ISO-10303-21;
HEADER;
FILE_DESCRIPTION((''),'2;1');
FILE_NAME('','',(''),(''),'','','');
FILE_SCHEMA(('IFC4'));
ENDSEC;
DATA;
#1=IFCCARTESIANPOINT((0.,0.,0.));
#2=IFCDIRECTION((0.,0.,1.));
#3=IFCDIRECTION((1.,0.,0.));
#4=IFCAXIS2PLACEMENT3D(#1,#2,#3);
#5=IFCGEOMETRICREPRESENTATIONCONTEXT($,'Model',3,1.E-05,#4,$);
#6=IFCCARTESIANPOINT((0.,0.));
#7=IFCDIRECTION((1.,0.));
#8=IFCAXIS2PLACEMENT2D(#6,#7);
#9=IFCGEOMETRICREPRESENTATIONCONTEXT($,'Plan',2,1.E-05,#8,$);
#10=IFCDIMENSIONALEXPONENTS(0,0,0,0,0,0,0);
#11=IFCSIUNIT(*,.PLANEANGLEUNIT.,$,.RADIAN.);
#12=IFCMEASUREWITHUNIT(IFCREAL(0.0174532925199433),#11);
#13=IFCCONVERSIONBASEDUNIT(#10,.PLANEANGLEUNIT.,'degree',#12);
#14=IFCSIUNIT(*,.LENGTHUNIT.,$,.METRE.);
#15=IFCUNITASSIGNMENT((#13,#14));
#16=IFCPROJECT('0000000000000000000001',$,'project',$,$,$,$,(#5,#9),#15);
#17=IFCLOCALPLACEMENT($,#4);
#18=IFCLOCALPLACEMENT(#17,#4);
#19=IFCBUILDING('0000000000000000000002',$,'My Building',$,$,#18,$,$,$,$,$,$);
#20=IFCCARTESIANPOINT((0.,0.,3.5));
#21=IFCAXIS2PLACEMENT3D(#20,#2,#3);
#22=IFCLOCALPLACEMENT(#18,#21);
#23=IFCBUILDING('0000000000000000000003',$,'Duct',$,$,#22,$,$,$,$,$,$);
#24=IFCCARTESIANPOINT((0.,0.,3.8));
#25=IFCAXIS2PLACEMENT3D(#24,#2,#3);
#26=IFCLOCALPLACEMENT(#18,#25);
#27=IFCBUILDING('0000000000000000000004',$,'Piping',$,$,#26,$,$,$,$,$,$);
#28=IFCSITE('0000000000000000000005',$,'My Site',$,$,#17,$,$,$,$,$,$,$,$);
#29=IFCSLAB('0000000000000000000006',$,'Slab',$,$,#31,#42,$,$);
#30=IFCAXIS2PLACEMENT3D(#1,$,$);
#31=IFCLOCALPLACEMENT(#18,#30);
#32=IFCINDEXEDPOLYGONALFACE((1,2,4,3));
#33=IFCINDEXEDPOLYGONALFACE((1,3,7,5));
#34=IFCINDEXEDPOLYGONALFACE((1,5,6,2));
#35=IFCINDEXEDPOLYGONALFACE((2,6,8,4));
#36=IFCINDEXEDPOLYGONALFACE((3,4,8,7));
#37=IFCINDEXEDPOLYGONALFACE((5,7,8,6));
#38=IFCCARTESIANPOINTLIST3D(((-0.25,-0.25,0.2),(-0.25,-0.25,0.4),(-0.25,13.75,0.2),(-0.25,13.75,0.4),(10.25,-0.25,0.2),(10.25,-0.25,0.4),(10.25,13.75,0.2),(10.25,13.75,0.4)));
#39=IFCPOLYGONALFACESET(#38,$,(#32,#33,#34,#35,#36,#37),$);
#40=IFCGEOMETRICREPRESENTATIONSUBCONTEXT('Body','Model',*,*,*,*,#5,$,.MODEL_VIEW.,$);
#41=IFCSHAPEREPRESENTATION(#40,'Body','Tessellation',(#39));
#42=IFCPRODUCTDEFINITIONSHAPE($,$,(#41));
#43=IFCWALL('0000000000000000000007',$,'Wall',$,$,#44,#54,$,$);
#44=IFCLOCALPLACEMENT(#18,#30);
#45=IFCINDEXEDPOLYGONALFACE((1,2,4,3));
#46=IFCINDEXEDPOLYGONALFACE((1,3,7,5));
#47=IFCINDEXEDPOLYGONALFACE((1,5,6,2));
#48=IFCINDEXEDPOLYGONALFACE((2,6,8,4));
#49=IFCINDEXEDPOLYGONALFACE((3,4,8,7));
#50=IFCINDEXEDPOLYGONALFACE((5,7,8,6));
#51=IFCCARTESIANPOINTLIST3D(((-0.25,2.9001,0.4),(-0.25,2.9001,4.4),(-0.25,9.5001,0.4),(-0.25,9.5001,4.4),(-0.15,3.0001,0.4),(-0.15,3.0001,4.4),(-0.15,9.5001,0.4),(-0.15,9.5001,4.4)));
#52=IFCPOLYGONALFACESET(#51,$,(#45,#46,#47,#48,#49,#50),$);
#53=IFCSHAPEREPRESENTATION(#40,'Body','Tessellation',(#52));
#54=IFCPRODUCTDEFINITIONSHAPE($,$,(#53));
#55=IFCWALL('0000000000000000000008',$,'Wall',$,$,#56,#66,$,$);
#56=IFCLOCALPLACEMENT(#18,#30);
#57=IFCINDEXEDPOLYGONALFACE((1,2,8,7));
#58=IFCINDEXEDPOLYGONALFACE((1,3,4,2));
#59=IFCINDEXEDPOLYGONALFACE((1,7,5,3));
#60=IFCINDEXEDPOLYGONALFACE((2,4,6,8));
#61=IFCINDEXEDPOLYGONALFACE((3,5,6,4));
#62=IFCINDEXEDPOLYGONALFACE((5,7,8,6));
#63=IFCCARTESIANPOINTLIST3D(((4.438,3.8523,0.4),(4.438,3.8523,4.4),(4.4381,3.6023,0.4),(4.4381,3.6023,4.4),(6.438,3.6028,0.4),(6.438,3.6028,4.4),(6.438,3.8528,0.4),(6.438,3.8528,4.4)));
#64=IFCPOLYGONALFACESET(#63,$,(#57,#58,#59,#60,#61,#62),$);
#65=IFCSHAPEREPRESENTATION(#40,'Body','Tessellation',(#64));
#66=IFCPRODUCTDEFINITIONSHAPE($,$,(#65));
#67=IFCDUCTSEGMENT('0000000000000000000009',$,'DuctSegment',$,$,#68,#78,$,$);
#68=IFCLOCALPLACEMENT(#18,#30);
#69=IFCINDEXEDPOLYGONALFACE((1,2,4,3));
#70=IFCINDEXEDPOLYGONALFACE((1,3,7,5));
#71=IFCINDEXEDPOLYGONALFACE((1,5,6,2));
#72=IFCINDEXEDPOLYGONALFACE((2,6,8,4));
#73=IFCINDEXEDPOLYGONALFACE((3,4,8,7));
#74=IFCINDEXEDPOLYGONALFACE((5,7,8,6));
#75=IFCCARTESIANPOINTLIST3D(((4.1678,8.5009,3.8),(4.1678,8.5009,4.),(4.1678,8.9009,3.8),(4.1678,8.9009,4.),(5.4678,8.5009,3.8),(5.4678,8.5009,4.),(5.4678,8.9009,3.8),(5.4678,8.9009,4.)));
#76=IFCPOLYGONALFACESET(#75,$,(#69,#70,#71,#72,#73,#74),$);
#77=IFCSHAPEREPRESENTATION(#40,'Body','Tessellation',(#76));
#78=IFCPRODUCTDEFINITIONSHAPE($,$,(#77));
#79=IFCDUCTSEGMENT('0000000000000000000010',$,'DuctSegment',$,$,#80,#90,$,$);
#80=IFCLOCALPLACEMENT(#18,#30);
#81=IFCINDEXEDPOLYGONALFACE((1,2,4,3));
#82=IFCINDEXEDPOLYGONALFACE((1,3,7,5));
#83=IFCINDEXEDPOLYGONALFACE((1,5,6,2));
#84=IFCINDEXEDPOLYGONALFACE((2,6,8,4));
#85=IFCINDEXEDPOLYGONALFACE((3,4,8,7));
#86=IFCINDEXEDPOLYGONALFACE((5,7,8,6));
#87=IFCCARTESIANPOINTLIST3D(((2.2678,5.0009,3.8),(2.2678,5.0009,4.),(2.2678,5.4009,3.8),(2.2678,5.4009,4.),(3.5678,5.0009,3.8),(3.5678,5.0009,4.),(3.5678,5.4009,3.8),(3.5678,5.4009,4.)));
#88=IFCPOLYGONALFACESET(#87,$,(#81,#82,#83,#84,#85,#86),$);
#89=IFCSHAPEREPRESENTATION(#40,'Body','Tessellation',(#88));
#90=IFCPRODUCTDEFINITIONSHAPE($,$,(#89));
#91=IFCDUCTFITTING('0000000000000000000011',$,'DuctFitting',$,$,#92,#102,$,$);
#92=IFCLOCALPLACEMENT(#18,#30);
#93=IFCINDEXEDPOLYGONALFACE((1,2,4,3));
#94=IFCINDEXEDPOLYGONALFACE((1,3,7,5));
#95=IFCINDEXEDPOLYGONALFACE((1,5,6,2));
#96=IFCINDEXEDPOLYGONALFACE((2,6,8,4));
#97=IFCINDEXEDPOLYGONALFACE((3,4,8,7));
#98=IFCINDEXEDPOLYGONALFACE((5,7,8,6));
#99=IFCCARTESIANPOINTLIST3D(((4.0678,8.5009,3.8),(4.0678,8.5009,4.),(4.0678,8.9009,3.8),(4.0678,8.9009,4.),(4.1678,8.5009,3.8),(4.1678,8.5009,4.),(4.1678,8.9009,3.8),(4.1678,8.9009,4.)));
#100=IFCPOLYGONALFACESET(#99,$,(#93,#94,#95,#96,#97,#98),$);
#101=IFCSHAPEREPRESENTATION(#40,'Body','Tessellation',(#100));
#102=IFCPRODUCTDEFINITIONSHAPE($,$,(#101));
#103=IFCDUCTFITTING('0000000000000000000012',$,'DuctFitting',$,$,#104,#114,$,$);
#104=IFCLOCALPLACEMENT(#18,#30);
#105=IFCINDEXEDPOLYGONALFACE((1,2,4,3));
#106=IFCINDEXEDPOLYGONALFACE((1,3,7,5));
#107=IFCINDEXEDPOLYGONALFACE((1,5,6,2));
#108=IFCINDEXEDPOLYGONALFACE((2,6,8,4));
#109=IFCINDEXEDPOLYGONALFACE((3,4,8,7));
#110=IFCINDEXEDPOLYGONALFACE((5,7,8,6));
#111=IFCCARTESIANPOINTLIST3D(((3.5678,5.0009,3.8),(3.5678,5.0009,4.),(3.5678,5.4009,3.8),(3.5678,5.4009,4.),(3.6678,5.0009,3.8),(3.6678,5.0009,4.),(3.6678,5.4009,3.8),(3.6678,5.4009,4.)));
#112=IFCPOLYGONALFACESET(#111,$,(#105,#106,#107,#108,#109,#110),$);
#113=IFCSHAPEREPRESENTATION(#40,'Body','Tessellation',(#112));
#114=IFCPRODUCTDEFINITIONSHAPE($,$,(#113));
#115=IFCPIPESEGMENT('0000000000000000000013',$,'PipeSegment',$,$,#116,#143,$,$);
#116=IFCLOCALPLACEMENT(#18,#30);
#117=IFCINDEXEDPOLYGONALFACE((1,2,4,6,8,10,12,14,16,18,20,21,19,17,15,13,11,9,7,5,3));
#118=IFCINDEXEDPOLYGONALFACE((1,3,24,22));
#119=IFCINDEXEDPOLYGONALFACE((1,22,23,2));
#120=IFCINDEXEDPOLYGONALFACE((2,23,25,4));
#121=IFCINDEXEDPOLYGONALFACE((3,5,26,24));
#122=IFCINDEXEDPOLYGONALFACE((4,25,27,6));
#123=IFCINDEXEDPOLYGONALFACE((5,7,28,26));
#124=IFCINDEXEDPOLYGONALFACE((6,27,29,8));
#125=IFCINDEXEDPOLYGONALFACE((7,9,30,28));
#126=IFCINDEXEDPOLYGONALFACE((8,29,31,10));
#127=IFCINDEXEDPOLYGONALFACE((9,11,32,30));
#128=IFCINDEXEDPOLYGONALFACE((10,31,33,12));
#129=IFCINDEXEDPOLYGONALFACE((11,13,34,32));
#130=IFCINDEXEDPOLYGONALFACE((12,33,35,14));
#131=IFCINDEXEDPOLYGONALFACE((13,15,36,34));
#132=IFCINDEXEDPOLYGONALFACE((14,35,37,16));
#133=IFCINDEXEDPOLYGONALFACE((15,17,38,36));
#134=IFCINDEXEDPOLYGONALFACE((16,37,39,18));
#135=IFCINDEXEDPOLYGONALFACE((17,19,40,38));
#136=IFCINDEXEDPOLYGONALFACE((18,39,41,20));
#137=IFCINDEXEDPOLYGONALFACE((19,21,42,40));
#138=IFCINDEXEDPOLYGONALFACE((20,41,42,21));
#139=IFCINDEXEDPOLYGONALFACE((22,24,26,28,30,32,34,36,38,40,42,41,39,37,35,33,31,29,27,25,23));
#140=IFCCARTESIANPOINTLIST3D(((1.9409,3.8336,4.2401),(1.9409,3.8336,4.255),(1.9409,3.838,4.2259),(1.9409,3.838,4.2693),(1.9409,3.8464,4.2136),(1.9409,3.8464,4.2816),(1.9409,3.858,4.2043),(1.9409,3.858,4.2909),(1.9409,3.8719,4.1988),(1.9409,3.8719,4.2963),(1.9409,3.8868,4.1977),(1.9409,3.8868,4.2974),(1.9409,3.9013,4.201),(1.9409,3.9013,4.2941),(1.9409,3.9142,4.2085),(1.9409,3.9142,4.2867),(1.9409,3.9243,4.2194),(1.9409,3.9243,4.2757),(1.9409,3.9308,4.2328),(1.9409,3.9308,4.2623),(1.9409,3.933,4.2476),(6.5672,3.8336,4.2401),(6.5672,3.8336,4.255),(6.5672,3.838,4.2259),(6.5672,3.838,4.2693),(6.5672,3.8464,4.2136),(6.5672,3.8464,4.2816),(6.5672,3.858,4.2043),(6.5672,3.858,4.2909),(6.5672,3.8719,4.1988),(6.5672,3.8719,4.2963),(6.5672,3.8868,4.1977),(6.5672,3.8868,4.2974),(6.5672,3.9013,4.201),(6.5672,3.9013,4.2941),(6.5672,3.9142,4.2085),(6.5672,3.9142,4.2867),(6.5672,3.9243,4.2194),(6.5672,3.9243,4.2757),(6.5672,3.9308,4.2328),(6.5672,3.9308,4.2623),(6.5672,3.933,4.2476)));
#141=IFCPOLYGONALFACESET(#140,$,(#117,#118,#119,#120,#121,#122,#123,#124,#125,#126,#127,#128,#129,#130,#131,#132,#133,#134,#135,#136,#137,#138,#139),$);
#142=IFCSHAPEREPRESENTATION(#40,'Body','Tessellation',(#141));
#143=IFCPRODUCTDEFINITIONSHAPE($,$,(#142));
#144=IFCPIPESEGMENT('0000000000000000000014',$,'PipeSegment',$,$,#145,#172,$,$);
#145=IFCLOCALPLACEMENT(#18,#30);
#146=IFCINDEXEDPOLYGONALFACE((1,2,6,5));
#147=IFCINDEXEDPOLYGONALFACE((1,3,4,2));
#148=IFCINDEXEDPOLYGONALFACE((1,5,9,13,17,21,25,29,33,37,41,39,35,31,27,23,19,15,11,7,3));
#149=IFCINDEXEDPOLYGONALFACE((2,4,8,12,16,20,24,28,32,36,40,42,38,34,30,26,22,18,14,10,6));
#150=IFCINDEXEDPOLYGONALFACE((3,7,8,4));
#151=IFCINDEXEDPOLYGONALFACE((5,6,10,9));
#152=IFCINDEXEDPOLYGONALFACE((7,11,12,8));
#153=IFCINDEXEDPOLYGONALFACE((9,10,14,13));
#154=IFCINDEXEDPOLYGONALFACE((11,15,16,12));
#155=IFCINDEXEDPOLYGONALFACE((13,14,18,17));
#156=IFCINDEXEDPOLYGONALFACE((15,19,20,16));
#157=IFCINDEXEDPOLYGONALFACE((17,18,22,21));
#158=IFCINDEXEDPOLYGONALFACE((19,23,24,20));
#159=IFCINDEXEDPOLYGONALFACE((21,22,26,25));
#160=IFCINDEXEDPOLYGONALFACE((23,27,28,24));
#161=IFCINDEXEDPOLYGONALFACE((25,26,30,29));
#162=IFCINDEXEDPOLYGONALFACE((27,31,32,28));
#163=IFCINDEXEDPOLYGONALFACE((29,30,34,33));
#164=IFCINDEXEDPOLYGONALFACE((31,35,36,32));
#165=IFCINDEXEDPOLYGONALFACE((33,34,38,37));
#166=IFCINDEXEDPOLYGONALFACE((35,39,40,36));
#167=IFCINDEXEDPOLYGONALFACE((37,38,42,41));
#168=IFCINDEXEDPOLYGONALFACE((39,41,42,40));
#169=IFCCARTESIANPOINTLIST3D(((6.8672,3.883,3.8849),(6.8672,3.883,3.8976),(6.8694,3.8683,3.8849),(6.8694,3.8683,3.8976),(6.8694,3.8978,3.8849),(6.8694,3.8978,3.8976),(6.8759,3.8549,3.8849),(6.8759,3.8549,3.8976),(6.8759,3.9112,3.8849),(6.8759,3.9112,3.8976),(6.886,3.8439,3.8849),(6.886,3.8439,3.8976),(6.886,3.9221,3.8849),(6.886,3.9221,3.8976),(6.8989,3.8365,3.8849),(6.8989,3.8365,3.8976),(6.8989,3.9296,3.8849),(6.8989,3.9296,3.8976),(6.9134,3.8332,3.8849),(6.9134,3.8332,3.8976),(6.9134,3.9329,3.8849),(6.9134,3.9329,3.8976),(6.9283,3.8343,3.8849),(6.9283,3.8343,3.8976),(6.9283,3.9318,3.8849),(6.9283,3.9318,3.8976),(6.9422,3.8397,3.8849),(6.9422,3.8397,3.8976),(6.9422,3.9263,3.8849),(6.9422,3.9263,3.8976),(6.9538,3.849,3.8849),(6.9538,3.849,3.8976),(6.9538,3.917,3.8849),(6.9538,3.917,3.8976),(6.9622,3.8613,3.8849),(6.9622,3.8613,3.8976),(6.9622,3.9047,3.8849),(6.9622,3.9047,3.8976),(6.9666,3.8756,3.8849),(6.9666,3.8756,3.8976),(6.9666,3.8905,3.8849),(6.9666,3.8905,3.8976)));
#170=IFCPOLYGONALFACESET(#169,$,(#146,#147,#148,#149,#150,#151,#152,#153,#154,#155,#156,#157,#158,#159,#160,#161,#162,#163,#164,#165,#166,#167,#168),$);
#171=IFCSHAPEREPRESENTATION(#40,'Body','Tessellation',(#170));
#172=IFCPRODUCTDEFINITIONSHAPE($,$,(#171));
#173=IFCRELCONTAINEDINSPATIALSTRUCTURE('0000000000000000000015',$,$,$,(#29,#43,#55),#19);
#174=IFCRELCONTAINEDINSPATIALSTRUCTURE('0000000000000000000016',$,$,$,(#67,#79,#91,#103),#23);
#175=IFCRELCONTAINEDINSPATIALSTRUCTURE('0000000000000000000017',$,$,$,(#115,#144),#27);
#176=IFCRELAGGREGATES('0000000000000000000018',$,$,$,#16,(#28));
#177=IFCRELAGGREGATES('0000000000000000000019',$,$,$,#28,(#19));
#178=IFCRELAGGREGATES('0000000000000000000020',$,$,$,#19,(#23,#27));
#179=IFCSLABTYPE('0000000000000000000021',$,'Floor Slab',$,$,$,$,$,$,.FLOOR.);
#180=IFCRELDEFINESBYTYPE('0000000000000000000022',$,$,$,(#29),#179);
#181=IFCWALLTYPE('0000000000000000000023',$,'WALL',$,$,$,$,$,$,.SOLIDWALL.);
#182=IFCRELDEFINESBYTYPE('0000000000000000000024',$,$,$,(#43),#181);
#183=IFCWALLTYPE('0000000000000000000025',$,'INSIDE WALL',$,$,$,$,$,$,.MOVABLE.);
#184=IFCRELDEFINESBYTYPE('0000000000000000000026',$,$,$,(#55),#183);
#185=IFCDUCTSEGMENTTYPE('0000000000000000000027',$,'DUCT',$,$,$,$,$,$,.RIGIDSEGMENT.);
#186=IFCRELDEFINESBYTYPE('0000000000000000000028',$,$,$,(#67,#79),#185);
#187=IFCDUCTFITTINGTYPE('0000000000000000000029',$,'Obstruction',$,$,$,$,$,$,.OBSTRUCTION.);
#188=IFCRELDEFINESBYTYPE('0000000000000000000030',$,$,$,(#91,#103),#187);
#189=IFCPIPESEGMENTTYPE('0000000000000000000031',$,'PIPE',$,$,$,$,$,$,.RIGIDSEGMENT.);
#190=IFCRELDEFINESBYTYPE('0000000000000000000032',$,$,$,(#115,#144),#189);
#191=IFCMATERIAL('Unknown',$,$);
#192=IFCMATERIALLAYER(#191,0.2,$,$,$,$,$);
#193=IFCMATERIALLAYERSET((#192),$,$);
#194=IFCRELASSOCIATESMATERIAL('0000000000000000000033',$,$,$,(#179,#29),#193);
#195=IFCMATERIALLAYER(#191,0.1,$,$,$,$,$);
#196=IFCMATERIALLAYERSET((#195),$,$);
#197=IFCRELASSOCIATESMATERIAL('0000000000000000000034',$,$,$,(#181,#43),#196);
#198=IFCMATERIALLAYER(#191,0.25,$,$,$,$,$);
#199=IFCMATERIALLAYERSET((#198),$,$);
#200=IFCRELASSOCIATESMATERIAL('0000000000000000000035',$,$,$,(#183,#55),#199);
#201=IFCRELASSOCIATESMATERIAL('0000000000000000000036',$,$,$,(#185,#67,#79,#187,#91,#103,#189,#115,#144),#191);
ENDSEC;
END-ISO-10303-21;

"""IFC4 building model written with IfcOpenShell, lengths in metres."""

from ifc_helpers import new_model, entity, si_unit, converted_unit, frame, origin_with_axes, origin_2d_with_axis, place, context, subcontext, project, spatial, line, indexed_curve, rectangle, circle, outline, extrude, material, layer, layer_set, layer_usage, material_profile, profile_set, profile_usage, type_object, element, save


model = new_model("IFC4")

# Units and contexts
model_context = context("Model", 3, precision=1e-05, world=origin_with_axes())
plan_context = context("Plan", 2, precision=1e-05, world=origin_2d_with_axis())
body_context = subcontext(model_context, "Body", "Model", "MODEL_VIEW")
ifc_project = project(units=[converted_unit("PLANEANGLEUNIT", "degree", entity("IfcReal", 0.0174532925199433), si_unit("PLANEANGLEUNIT", "RADIAN"), dimensions=[0, 0, 0, 0, 0, 0, 0]), si_unit("LENGTHUNIT", "METRE")], contexts=[model_context, plan_context])

# Site, building
site_placement = place(None, origin_with_axes())
site = spatial("IfcSite", under=ifc_project, at=site_placement, Name="My Site")
building_1_placement = place(site_placement, origin_with_axes())
building_1 = spatial("IfcBuilding", under=site, at=building_1_placement, Name="My Building")

# Slab
ifc_material = material(Name="Unknown")
ifc_layer_1 = layer(ifc_material, 0.2)
ifc_layer_set_1 = layer_set([ifc_layer_1])
ifc_layer_usage_1 = layer_usage(ifc_layer_set_1, "AXIS3", "POSITIVE", 0.0)
slab_type = type_object("IfcSlabType", Name="Floor Slab", PredefinedType="FLOOR", material=ifc_layer_set_1)
slab_placement = place(building_1_placement, frame((-0.25, -0.25, 0.2), z_axis=(0.0, 0.0, 1.0), x_axis=(1.0, 0.0, 0.0)))
element("IfcSlab", 1, at=slab_placement, inside=building_1, type_object=slab_type, material=ifc_layer_usage_1, Name="Slab", context=body_context, shape_type="SweptSolid", body=[
    extrude(outline(indexed_curve([(0.0, 0.0), (10.5, 0.0), (10.5, 14.0), (0.0, 14.0), (0.0, 0.0)])), None, (0.0, 0.0, 1.0), 0.2),
])

# Walls
ifc_layer_2 = layer(ifc_material, 0.1)
ifc_layer_set_2 = layer_set([ifc_layer_2])
ifc_layer_usage_2 = layer_usage(ifc_layer_set_2, "AXIS2", "POSITIVE", 0.0)
wall_type_1 = type_object("IfcWallType", Name="WALL", PredefinedType="SOLIDWALL", material=ifc_layer_set_2)
wall_1_placement = place(building_1_placement, frame((-0.15, 3.0001, 0.4), z_axis=(0.0, 0.0, 1.0), x_axis=(0.0, 1.0, 0.0)))
element("IfcWall", 2, at=wall_1_placement, inside=building_1, type_object=wall_type_1, material=ifc_layer_usage_2, Name="Wall", context=body_context, shape_type="SweptSolid", body=[
    extrude(outline(indexed_curve([(0.0, 0.0), (-0.1, 0.1), (6.5, 0.1), (6.5, 0.0)], segments=[line(1, 2, 3, 4, 1)])), origin_with_axes(), (0.0, 0.0, 1.0), 4.0),
])
ifc_layer_3 = layer(ifc_material, 0.25)
ifc_layer_set_3 = layer_set([ifc_layer_3])
ifc_layer_usage_3 = layer_usage(ifc_layer_set_3, "AXIS2", "POSITIVE", 0.0)
wall_type_2 = type_object("IfcWallType", Name="INSIDE WALL", PredefinedType="MOVABLE", material=ifc_layer_set_3)
wall_2_placement = place(building_1_placement, frame((6.438, 3.8528, 0.4), z_axis=(0.0, 0.0, 1.0), x_axis=(-1.0, -0.000252, 0.0)))
element("IfcWall", 3, at=wall_2_placement, inside=building_1, type_object=wall_type_2, material=ifc_layer_usage_3, Name="Wall", context=body_context, shape_type="SweptSolid", body=[
    extrude(outline(indexed_curve([(0.0, 0.0), (0.0, 0.25), (2.0, 0.25), (2.0, 0.0)], segments=[line(1, 2, 3, 4, 1)])), origin_with_axes(), (0.0, 0.0, 1.0), 4.0),
])

# Shared definitions
building_2_placement = place(building_1_placement, frame((0.0, 0.0, 3.5), z_axis=(0.0, 0.0, 1.0), x_axis=(1.0, 0.0, 0.0)))
building_2 = spatial("IfcBuilding", under=building_1, at=building_2_placement, Name="Duct")

# Duct segments
ifc_material_profile_1 = material_profile(ifc_material, rectangle(XDim=0.4, YDim=0.2))
ifc_profile_set_1 = profile_set([ifc_material_profile_1])
ifc_profile_usage_1 = profile_usage(ifc_profile_set_1, cardinal=5)
duct_segment_type = type_object("IfcDuctSegmentType", Name="DUCT", PredefinedType="RIGIDSEGMENT", material=ifc_profile_set_1)
duct_segment_1_placement = place(building_2_placement, frame((5.4678, 8.7009, 0.4), z_axis=(-1.0, 0.0, 0.0), x_axis=(0.0, 1.0, 0.0)))
element("IfcDuctSegment", 4, at=duct_segment_1_placement, inside=building_2, type_object=duct_segment_type, material=ifc_profile_usage_1, Name="DuctSegment", context=body_context, shape_type="SweptSolid", body=[
    extrude(rectangle(XDim=0.4, YDim=0.2), origin_with_axes(), (0.0, 0.0, 1.0), 1.3),
])
ifc_profile_usage_2 = profile_usage(ifc_profile_set_1, cardinal=5)
duct_segment_2_placement = place(building_2_placement, frame((3.5678, 5.2009, 0.4), z_axis=(-1.0, 0.0, 0.0), x_axis=(0.0, -1.0, 0.0)))
element("IfcDuctSegment", 5, at=duct_segment_2_placement, inside=building_2, type_object=duct_segment_type, material=ifc_profile_usage_2, Name="DuctSegment", context=body_context, shape_type="SweptSolid", body=[
    extrude(rectangle(XDim=0.4, YDim=0.2), origin_with_axes(), (0.0, 0.0, 1.0), 1.3),
])

# Duct fittings
ifc_material_profile_2 = material_profile(ifc_material, rectangle(XDim=0.4, YDim=0.2))
ifc_profile_set_2 = profile_set([ifc_material_profile_2])
ifc_profile_usage_3 = profile_usage(ifc_profile_set_2, cardinal=5)
duct_fitting_type = type_object("IfcDuctFittingType", Name="Obstruction", PredefinedType="OBSTRUCTION", material=ifc_profile_set_2)
duct_fitting_1_placement = place(building_2_placement, frame((4.1678, 8.7009, 0.4), z_axis=(-1.0, 0.0, 0.0), x_axis=(0.0, 1.0, 0.0)))
element("IfcDuctFitting", 6, at=duct_fitting_1_placement, inside=building_2, type_object=duct_fitting_type, material=ifc_profile_usage_3, Name="DuctFitting", context=body_context, shape_type="SweptSolid", body=[
    extrude(rectangle(XDim=0.4, YDim=0.2), origin_with_axes(), (0.0, 0.0, 1.0), 0.1),
])
ifc_profile_usage_4 = profile_usage(ifc_profile_set_2, cardinal=5)
duct_fitting_2_placement = place(building_2_placement, frame((3.6678, 5.2009, 0.4), z_axis=(-1.0, 0.0, 0.0), x_axis=(0.0, -1.0, 0.0)))
element("IfcDuctFitting", 7, at=duct_fitting_2_placement, inside=building_2, type_object=duct_fitting_type, material=ifc_profile_usage_4, Name="DuctFitting", context=body_context, shape_type="SweptSolid", body=[
    extrude(rectangle(XDim=0.4, YDim=0.2), origin_with_axes(), (0.0, 0.0, 1.0), 0.1),
])

# Shared definitions
building_3_placement = place(building_1_placement, frame((0.0, 0.0, 3.8), z_axis=(0.0, 0.0, 1.0), x_axis=(1.0, 0.0, 0.0)))
building_3 = spatial("IfcBuilding", under=building_1, at=building_3_placement, Name="Piping")

# Pipe segments
ifc_material_profile_3 = material_profile(ifc_material, circle(Radius=0.05))
ifc_profile_set_3 = profile_set([ifc_material_profile_3])
ifc_profile_usage_5 = profile_usage(ifc_profile_set_3, cardinal=5)
pipe_segment_type = type_object("IfcPipeSegmentType", Name="PIPE", PredefinedType="RIGIDSEGMENT", material=ifc_profile_set_3)
pipe_segment_1_placement = place(building_3_placement, frame((1.9409, 3.883, 0.4476), z_axis=(1.0, -0.000001, 0.000001), x_axis=(0.000001, 1.0, 0.0)))
element("IfcPipeSegment", 8, at=pipe_segment_1_placement, inside=building_3, type_object=pipe_segment_type, material=ifc_profile_usage_5, Name="PipeSegment", context=body_context, shape_type="SweptSolid", body=[
    extrude(circle(Radius=0.05), origin_with_axes(), (0.0, 0.0, 1.0), 4.6263),
])
ifc_profile_usage_6 = profile_usage(ifc_profile_set_3, cardinal=5)
pipe_segment_2_placement = place(building_3_placement, frame((6.9172, 3.883, 0.0976), z_axis=(0.0, 0.0, -1.0), x_axis=(-1.0, 0.0, 0.0)))
element("IfcPipeSegment", 9, at=pipe_segment_2_placement, inside=building_3, type_object=pipe_segment_type, material=ifc_profile_usage_6, Name="PipeSegment", context=body_context, shape_type="SweptSolid", body=[
    extrude(circle(Radius=0.05), origin_with_axes(), (0.0, 0.0, 1.0), 0.0127),
])

save(model, "model.ifc")
